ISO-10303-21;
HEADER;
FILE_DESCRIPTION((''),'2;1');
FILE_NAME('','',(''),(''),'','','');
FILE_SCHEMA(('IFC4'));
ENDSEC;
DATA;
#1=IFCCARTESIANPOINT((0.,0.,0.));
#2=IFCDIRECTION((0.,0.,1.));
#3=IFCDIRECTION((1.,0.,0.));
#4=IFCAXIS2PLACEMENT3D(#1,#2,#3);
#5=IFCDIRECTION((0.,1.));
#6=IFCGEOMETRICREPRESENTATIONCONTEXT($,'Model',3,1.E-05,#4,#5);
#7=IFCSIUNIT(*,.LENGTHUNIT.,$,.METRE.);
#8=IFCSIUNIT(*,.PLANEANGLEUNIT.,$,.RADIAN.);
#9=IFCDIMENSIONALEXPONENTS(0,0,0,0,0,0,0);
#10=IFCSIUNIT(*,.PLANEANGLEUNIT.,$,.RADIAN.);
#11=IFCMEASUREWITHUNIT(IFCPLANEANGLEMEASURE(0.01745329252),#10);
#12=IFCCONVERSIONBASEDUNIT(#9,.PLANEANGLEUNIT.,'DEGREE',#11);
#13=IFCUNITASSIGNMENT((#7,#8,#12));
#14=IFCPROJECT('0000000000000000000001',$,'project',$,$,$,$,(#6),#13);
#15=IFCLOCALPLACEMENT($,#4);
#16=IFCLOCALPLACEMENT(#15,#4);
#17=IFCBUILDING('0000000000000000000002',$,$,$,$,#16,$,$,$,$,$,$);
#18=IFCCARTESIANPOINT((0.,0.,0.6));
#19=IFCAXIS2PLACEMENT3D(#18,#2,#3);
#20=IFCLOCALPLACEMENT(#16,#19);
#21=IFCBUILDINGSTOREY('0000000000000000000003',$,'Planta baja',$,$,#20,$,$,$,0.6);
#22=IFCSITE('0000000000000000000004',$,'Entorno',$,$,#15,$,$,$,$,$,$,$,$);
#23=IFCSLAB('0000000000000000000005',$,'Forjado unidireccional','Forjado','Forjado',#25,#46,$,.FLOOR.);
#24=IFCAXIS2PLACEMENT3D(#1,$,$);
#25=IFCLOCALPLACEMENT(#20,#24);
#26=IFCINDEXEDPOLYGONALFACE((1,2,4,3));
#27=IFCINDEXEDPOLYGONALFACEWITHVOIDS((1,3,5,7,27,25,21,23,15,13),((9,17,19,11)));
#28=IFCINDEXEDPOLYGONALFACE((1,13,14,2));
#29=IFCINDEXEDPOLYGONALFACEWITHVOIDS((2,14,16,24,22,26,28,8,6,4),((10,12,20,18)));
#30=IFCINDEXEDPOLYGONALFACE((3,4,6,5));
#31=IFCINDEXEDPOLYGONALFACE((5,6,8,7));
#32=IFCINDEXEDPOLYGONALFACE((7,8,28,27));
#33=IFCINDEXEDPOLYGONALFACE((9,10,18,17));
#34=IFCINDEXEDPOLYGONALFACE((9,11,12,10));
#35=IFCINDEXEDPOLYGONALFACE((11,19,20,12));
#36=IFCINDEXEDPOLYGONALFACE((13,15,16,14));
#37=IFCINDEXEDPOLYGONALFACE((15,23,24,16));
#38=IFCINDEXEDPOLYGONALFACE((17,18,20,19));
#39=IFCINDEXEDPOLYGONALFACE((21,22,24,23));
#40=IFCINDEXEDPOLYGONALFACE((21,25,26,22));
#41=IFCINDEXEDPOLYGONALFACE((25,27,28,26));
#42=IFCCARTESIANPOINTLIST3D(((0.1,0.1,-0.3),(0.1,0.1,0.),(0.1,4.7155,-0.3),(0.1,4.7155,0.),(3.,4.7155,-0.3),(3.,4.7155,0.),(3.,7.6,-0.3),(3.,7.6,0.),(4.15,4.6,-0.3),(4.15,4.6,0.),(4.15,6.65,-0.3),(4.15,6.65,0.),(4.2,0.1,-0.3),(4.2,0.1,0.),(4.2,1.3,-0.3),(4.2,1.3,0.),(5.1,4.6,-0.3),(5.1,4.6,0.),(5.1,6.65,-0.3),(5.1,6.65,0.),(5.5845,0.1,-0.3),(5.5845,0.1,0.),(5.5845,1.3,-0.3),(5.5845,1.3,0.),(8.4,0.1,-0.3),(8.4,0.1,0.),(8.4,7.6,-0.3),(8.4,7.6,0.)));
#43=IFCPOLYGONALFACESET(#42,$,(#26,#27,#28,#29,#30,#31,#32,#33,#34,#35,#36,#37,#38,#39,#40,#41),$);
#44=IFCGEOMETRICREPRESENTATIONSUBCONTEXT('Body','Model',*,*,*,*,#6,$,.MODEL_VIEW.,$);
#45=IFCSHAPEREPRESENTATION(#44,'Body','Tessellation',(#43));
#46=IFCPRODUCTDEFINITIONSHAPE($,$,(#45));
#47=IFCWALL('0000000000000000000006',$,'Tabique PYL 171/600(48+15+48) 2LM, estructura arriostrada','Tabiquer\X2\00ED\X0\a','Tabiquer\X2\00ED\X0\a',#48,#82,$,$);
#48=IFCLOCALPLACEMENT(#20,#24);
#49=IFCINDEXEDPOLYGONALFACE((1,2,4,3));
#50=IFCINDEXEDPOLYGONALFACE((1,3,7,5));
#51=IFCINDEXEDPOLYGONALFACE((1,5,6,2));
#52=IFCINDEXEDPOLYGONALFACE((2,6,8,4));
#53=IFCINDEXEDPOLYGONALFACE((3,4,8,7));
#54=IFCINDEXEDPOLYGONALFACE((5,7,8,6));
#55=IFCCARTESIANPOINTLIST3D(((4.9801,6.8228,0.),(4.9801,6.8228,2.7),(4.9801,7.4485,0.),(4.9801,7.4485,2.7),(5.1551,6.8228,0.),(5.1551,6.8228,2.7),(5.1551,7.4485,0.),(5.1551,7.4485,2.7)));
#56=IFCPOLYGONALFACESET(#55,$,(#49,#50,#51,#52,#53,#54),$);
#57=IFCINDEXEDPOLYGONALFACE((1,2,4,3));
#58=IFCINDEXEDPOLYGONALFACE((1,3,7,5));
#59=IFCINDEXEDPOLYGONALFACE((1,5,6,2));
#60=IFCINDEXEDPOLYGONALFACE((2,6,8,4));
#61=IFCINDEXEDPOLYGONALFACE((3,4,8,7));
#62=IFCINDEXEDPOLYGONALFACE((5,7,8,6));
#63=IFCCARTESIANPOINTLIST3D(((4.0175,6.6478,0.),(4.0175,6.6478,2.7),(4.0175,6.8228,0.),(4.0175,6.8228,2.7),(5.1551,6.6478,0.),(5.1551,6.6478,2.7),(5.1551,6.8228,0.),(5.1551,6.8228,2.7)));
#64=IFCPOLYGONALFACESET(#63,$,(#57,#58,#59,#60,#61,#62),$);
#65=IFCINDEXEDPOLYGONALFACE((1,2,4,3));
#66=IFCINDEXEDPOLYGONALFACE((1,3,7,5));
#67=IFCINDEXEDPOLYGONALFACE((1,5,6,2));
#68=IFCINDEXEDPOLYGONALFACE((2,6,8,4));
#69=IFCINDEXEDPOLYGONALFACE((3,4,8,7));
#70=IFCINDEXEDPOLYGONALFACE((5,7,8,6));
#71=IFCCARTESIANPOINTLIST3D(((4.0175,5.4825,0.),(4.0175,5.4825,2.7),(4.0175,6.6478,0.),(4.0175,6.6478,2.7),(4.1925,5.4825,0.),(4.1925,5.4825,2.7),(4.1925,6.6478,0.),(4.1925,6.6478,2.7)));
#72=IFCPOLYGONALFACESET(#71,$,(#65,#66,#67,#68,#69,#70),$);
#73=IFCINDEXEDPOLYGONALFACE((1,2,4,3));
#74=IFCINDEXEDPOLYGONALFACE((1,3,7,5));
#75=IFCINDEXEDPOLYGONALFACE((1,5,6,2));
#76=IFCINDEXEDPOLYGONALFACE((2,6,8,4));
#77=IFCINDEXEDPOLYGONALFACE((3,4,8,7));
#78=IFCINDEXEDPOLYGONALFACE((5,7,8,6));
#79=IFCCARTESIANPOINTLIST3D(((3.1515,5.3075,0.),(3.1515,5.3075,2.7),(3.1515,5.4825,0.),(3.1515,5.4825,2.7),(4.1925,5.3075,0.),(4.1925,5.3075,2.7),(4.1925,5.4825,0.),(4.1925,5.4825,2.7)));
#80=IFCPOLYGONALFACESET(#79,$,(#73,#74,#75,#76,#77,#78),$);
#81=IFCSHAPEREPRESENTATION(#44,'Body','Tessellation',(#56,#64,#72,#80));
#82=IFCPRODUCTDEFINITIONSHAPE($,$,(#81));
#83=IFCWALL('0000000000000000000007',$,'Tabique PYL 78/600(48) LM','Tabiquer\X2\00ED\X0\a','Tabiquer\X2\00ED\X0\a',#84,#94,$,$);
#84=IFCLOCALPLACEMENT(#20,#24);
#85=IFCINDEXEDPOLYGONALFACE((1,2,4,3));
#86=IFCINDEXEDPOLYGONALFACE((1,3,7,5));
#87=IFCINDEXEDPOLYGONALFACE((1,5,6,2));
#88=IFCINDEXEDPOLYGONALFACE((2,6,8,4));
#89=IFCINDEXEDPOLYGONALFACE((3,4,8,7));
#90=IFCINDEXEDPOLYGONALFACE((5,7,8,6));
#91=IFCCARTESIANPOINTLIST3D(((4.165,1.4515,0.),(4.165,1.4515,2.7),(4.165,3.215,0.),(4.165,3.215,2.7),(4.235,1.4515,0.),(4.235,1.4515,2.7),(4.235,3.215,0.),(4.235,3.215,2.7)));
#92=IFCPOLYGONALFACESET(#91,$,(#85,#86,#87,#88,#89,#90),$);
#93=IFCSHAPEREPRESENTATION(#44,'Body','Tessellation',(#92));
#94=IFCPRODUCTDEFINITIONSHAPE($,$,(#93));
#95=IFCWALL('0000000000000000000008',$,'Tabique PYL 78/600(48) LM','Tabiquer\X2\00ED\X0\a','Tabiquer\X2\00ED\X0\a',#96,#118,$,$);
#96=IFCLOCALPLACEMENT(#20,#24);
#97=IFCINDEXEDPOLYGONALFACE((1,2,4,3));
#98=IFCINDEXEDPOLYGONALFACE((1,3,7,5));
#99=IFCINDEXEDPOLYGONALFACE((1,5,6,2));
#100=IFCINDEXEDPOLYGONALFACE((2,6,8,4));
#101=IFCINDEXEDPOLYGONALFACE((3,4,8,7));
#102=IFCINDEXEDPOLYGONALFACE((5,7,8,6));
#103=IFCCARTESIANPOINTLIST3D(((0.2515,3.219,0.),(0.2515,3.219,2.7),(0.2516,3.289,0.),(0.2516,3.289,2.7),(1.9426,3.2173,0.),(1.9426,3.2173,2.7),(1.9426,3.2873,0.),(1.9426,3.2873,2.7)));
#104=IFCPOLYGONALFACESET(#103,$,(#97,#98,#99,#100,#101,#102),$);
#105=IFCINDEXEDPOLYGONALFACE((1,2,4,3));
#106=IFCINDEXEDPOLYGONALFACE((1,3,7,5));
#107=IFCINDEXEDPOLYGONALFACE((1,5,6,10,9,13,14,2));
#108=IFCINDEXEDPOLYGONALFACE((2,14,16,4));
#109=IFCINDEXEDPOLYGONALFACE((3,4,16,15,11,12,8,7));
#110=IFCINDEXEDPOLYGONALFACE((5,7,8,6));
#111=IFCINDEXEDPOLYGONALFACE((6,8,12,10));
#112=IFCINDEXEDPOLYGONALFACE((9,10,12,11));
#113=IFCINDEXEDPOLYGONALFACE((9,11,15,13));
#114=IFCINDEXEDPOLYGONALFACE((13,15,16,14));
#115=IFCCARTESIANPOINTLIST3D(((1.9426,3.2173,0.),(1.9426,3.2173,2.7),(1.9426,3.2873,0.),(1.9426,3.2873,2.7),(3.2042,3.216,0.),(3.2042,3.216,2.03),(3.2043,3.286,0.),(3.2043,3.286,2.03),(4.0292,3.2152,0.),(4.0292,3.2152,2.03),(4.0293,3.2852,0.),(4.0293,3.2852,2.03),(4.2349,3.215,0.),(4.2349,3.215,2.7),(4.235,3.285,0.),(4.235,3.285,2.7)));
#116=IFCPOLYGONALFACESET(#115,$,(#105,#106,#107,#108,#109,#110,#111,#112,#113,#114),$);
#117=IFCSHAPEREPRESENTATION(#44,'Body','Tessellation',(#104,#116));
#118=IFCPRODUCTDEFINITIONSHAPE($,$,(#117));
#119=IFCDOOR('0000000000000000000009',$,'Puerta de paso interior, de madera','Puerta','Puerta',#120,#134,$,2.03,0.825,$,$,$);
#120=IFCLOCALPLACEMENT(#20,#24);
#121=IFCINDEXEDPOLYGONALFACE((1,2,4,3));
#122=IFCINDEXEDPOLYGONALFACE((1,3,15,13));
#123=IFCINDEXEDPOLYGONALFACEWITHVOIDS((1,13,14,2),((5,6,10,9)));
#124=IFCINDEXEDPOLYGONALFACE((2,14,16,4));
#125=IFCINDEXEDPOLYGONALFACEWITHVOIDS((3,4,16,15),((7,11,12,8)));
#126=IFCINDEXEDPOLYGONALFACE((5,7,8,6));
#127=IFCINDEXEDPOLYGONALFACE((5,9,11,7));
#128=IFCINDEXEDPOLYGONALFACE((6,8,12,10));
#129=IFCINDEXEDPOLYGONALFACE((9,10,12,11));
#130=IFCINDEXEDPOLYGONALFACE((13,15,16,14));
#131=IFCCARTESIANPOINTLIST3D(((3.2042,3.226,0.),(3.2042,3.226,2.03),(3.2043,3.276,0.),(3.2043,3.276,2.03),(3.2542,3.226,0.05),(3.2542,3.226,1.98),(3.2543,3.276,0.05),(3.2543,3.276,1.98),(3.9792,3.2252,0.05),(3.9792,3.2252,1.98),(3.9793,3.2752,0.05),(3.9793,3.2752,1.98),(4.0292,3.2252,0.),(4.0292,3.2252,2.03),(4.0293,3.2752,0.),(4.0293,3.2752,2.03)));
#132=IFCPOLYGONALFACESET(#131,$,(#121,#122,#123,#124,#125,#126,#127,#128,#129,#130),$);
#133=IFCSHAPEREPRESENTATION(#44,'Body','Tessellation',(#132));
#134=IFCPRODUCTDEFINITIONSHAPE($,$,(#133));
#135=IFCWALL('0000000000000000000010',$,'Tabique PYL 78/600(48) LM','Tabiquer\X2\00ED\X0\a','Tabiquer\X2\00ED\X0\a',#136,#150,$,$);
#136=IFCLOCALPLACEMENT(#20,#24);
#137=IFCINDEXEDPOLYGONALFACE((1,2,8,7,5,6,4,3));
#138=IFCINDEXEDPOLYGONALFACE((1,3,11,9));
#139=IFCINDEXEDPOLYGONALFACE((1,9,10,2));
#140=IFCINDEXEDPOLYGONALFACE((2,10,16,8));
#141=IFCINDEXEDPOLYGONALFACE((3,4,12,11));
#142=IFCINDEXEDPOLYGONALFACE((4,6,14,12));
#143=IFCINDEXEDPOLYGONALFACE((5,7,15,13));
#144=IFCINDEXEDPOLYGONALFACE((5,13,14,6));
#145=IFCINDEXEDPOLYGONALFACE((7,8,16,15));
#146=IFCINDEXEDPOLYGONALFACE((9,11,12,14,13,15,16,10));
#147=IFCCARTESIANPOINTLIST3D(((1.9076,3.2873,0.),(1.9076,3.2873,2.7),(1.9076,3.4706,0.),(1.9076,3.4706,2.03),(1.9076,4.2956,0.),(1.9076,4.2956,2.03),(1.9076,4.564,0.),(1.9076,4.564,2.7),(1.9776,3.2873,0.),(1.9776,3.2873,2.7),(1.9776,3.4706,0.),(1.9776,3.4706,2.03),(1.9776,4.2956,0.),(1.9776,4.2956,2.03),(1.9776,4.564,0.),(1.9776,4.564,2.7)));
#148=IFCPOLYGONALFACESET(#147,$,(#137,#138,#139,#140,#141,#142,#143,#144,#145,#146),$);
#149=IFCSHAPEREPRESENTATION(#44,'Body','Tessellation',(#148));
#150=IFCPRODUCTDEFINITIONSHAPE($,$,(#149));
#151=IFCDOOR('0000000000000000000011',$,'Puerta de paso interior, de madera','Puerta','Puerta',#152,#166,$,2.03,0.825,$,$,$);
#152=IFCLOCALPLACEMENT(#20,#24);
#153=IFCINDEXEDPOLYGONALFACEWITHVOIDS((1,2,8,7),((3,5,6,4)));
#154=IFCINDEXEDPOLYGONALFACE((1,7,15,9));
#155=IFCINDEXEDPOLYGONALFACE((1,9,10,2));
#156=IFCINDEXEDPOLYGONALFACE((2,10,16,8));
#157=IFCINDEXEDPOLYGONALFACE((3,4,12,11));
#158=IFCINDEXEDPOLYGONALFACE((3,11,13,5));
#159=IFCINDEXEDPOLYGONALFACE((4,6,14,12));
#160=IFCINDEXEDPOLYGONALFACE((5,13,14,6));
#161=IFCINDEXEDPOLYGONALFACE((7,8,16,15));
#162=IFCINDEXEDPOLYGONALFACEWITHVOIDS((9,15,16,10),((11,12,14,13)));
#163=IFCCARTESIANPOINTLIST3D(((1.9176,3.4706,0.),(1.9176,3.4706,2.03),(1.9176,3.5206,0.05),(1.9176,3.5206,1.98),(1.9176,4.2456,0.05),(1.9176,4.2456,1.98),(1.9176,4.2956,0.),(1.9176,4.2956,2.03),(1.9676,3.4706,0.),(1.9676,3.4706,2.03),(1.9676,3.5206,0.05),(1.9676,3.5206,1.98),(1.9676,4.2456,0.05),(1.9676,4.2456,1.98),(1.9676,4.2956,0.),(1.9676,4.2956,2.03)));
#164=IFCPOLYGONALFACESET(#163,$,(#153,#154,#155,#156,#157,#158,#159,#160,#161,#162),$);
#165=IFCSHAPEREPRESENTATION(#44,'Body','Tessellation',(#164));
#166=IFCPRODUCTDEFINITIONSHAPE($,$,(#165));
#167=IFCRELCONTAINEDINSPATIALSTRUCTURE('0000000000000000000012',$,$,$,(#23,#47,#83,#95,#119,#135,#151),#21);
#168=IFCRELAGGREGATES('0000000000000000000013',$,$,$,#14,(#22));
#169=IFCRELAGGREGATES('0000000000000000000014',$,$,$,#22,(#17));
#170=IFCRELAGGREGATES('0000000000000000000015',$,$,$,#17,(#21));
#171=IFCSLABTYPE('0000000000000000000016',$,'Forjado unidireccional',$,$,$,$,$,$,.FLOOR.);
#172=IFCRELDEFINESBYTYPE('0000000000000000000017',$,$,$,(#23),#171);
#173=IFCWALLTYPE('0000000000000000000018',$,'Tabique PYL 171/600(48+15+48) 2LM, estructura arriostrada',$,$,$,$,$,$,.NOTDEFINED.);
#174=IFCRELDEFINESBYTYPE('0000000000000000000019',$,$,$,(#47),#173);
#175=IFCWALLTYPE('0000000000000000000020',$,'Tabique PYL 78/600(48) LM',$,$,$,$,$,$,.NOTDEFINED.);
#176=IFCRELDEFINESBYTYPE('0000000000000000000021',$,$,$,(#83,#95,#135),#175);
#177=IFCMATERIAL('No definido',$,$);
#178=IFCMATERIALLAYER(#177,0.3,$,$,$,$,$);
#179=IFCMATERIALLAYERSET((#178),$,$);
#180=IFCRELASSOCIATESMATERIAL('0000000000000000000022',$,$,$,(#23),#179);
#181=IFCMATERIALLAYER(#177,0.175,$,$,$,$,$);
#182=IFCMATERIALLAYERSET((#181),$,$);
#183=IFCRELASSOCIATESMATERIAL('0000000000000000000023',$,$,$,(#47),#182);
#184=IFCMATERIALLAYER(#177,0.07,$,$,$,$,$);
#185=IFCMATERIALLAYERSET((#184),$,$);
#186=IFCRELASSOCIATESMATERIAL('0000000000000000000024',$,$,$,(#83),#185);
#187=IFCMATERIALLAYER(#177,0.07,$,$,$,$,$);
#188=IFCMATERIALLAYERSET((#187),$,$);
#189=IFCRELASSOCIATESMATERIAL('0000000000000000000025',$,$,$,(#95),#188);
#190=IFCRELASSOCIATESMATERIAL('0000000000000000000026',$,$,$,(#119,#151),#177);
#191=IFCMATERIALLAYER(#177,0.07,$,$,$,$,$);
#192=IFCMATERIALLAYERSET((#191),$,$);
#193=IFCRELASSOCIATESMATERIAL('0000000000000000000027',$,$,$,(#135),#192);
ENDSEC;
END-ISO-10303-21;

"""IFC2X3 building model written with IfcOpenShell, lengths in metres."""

from ifc_helpers import new_model, entity, si_unit, converted_unit, direction, frame, origin_with_axes, origin_2d_with_axis, place, context, subcontext, project, spatial, polyline, rectangle, hollow_rectangle, outline, extrude, shape, material, layer, layer_set, layer_usage, type_object, element, fill, save


model = new_model("IFC2X3")

# Units and contexts
model_context = context("Model", 3, precision=1e-05, world=origin_with_axes(), true_north=direction((0.0, 1.0)))
body_context = subcontext(model_context, "Body", "Model", "MODEL_VIEW")
footprint_context = subcontext(model_context, "FootPrint", "Model", "MODEL_VIEW")
ifc_project = project(units=[si_unit("LENGTHUNIT", "METRE"), si_unit("PLANEANGLEUNIT", "RADIAN"), converted_unit("PLANEANGLEUNIT", "DEGREE", entity("IfcPlaneAngleMeasure", 0.01745329252), si_unit("PLANEANGLEUNIT", "RADIAN"), dimensions=[0, 0, 0, 0, 0, 0, 0])], contexts=[model_context])

# Site, building, storey
site_placement = place(None, origin_with_axes())
site = spatial("IfcSite", under=ifc_project, at=site_placement, Name="Entorno")
building_placement = place(site_placement, origin_with_axes())
building = spatial("IfcBuilding", under=site, at=building_placement)
storey_placement = place(building_placement, frame((0.0, 0.0, 0.6), z_axis=(0.0, 0.0, 1.0), x_axis=(1.0, 0.0, 0.0)))
storey = spatial("IfcBuildingStorey", under=building, at=storey_placement, Name="Planta baja", Elevation=0.6)

# Slab, opening
ifc_material = material(Name="No definido")
ifc_layer_1 = layer(ifc_material, 0.3)
ifc_layer_set_1 = layer_set([ifc_layer_1])
ifc_layer_usage_1 = layer_usage(ifc_layer_set_1, "AXIS3", "POSITIVE", 0.0)
slab_type_1 = type_object("IfcSlabType", Name="Forjado unidireccional", PredefinedType="FLOOR")
slab_placement = place(storey_placement, frame((4.2, 0.1, -0.3), z_axis=(0.0, 0.0, 1.0), x_axis=(1.0, 0.0, 0.0)))
slab = element("IfcSlab", 1, at=slab_placement, inside=storey, type_object=slab_type_1, material=ifc_layer_usage_1, Name="Forjado unidireccional", Description="Forjado", ObjectType="Forjado", PredefinedType="FLOOR", context=body_context, shape_type="SweptSolid", body=[
    extrude(outline(polyline([(0.0, 0.0), (0.0, 1.2), (1.3845, 1.2), (1.3845, 0.0), (4.2, 0.0), (4.2, 7.5), (-1.2, 7.5), (-1.2, 4.6155), (-4.1, 4.6155), (-4.1, 0.0), (0.0, 0.0)])), origin_with_axes(), (0.0, 0.0, 1.0), 0.3),
])
opening_1_placement = place(slab_placement, frame((-0.05, 4.5, -0.01), z_axis=(0.0, 0.0, 1.0), x_axis=(1.0, 0.0, 0.0)))
element("IfcOpeningElement", 2, at=opening_1_placement, cuts=slab, ObjectType="No definido", context=body_context, shape_type="SweptSolid", body=[
    extrude(outline(polyline([(0.0, 0.0), (0.95, 0.0), (0.95, 2.05), (0.0, 2.05), (0.0, 0.0)])), origin_with_axes(), (0.0, 0.0, 1.0), 0.32),
])

# Walls
ifc_layer_2 = layer(ifc_material, 0.175)
ifc_layer_set_2 = layer_set([ifc_layer_2])
ifc_layer_usage_2 = layer_usage(ifc_layer_set_2, "AXIS2", "POSITIVE", -0.0875)
wall_type_1 = type_object("IfcWallType", Name="Tabique PYL 171/600(48+15+48) 2LM, estructura arriostrada")
wall_1_placement = place(storey_placement, frame((5.0676, 7.6, 0.0), z_axis=(0.0, 0.0, 1.0), x_axis=(0.0, -1.0, 0.0)))
element("IfcWall", 3, at=wall_1_placement, inside=storey, type_object=wall_type_1, material=ifc_layer_usage_2, Name="Tabique PYL 171/600(48+15+48) 2LM, estructura arriostrada", Description="Tabiquería", ObjectType="Tabiquería", context=body_context, shape_type="SolidModel", body=[
    extrude(outline(polyline([(-0.3129, -1.35), (0.3129, -1.35), (0.3129, 1.35), (-0.3129, 1.35), (-0.3129, -1.35)])), frame((0.4643, 0.0875, 1.35), z_axis=(0.0, -1.0, 0.0), x_axis=(1.0, 0.0, 0.0)), (0.0, 0.0, 1.0), 0.175),
    extrude(outline(polyline([(-0.5688, -1.35), (0.5688, -1.35), (0.5688, 1.35), (-0.5688, 1.35), (-0.5688, -1.35)])), frame((0.9522, -0.4813, 1.35), z_axis=(-1.0, 0.0, 0.0), x_axis=(0.0, -1.0, 0.0)), (0.0, 0.0, 1.0), 0.175),
    extrude(outline(polyline([(-0.5827, -1.35), (0.5827, -1.35), (0.5827, 1.35), (-0.5827, 1.35), (-0.5827, -1.35)])), frame((1.5349, -0.8751, 1.35), z_axis=(0.0, -1.0, 0.0), x_axis=(1.0, 0.0, 0.0)), (0.0, 0.0, 1.0), 0.175),
    extrude(outline(polyline([(-0.5205, -1.35), (0.5205, -1.35), (0.5205, 1.35), (-0.5205, 1.35), (-0.5205, -1.35)])), frame((2.2925, -1.3956, 1.35), z_axis=(-1.0, 0.0, 0.0), x_axis=(0.0, -1.0, 0.0)), (0.0, 0.0, 1.0), 0.175),
])
ifc_layer_3 = layer(ifc_material, 0.07)
ifc_layer_set_3 = layer_set([ifc_layer_3])
ifc_layer_usage_3 = layer_usage(ifc_layer_set_3, "AXIS2", "POSITIVE", -0.035)
wall_type_2 = type_object("IfcWallType", Name="Tabique PYL 78/600(48) LM")
wall_2_placement = place(storey_placement, frame((4.2, 1.3, 0.0), z_axis=(0.0, 0.0, 1.0), x_axis=(0.0, 1.0, 0.0)))
element("IfcWall", 4, at=wall_2_placement, inside=storey, type_object=wall_type_2, material=ifc_layer_usage_3, Name="Tabique PYL 78/600(48) LM", Description="Tabiquería", ObjectType="Tabiquería", context=body_context, shape_type="SolidModel", body=[
    extrude(outline(polyline([(-0.8817, -1.35), (0.8817, -1.35), (0.8817, 1.35), (-0.8817, 1.35), (-0.8817, -1.35)])), frame((1.0332, 0.035, 1.35), z_axis=(0.0, -1.0, 0.0), x_axis=(1.0, 0.0, 0.0)), (0.0, 0.0, 1.0), 0.07),
])

# Walls, openings, doors
ifc_layer_4 = layer(ifc_material, 0.07)
ifc_layer_set_4 = layer_set([ifc_layer_4])
ifc_layer_usage_4 = layer_usage(ifc_layer_set_4, "AXIS2", "POSITIVE", -0.035)
wall_3_placement = place(storey_placement, frame((0.1, 3.2542, 0.0), z_axis=(0.0, 0.0, 1.0), x_axis=(0.999999, -0.001016, 0.0)))
wall_3 = element("IfcWall", 5, at=wall_3_placement, inside=storey, type_object=wall_type_2, material=ifc_layer_usage_4, Name="Tabique PYL 78/600(48) LM", Description="Tabiquería", ObjectType="Tabiquería", context=body_context, shape_type="SolidModel", body=[
    extrude(outline(polyline([(-0.8455, -1.35), (0.8455, -1.35), (0.8455, 1.35), (-0.8455, 1.35), (-0.8455, -1.35)])), frame((0.9971, 0.035, 1.35), z_axis=(0.0, -1.0, 0.0), x_axis=(1.0, 0.0, 0.0)), (0.0, 0.0, 1.0), 0.07),
    extrude(outline(polyline([(-1.1462, -1.35), (1.1462, -1.35), (1.1462, 1.35), (-1.1462, 1.35), (-1.1462, -1.35)])), frame((2.9888, 0.035, 1.35), z_axis=(0.0, -1.0, 0.0), x_axis=(1.0, 0.0, 0.0)), (0.0, 0.0, 1.0), 0.07),
])
opening_2_placement = place(wall_3_placement, frame((3.5168, 0.0, 1.015), z_axis=(0.0, 0.0, 1.0), x_axis=(1.0, 0.0, 0.0)))
cartesian_point_1 = entity("IfcCartesianPoint", [-0.4125, -0.035])
opening_2 = element("IfcOpeningElement", 6, at=opening_2_placement, cuts=wall_3, ObjectType="No definido", shapes=[
    shape(body_context, "Body", "SweptSolid", [extrude(rectangle(XDim=2.03, YDim=0.825, at=origin_2d_with_axis()), frame((0.0, -0.035, 0.0), z_axis=(0.0, 1.0, 0.0), x_axis=(0.0, 0.0, 1.0)), (0.0, 0.0, 1.0), 0.07)]),
    shape(footprint_context, "FootPrint", "GeometricCurveSet", [entity("IfcGeometricCurveSet", [entity("IfcPolyline", [cartesian_point_1, entity("IfcCartesianPoint", [0.4125, -0.035]), entity("IfcCartesianPoint", [0.4125, 0.035]), entity("IfcCartesianPoint", [-0.4125, 0.035]), cartesian_point_1])])]),
])
door_1_placement = place(opening_2_placement, origin_with_axes())
door_1 = element("IfcDoor", 7, at=door_1_placement, inside=storey, material=ifc_material, Name="Puerta de paso interior, de madera", Description="Puerta", ObjectType="Puerta", OverallHeight=2.03, OverallWidth=0.825, context=body_context, shape_type="SweptSolid", body=[
    extrude(hollow_rectangle(XDim=0.825, YDim=2.03, WallThickness=0.05, InnerFilletRadius=0.0, OuterFilletRadius=0.0, at=origin_2d_with_axis()), frame((0.0, 0.025, 0.0), z_axis=(0.0, -1.0, 0.0), x_axis=(1.0, 0.0, 0.0)), (0.0, 0.0, 1.0), 0.05),
])
fill(opening_2, door_1)
ifc_layer_5 = layer(ifc_material, 0.07)
ifc_layer_set_5 = layer_set([ifc_layer_5])
ifc_layer_usage_5 = layer_usage(ifc_layer_set_5, "AXIS2", "POSITIVE", -0.035)
wall_4_placement = place(storey_placement, frame((1.9426, 3.25, 0.0), z_axis=(0.0, 0.0, 1.0), x_axis=(0.0, 1.0, 0.0)))
wall_4 = element("IfcWall", 8, at=wall_4_placement, inside=storey, type_object=wall_type_2, material=ifc_layer_usage_5, Name="Tabique PYL 78/600(48) LM", Description="Tabiquería", ObjectType="Tabiquería", context=body_context, shape_type="SolidModel", body=[
    extrude(outline(polyline([(-0.6383, -1.35), (0.6383, -1.35), (0.6383, 1.35), (-0.6383, 1.35), (-0.6383, -1.35)])), frame((0.6757, 0.035, 1.35), z_axis=(0.0, -1.0, 0.0), x_axis=(1.0, 0.0, 0.0)), (0.0, 0.0, 1.0), 0.07),
])
opening_3_placement = place(wall_4_placement, frame((0.6331, 0.0, 1.015), z_axis=(0.0, 0.0, 1.0), x_axis=(1.0, 0.0, 0.0)))
cartesian_point_2 = entity("IfcCartesianPoint", [-0.4125, -0.035])
opening_3 = element("IfcOpeningElement", 9, at=opening_3_placement, cuts=wall_4, ObjectType="No definido", shapes=[
    shape(body_context, "Body", "SweptSolid", [extrude(rectangle(XDim=2.03, YDim=0.825, at=origin_2d_with_axis()), frame((0.0, -0.035, 0.0), z_axis=(0.0, 1.0, 0.0), x_axis=(0.0, 0.0, 1.0)), (0.0, 0.0, 1.0), 0.07)]),
    shape(footprint_context, "FootPrint", "GeometricCurveSet", [entity("IfcGeometricCurveSet", [entity("IfcPolyline", [cartesian_point_2, entity("IfcCartesianPoint", [0.4125, -0.035]), entity("IfcCartesianPoint", [0.4125, 0.035]), entity("IfcCartesianPoint", [-0.4125, 0.035]), cartesian_point_2])])]),
])
door_2_placement = place(opening_3_placement, origin_with_axes())
door_2 = element("IfcDoor", 10, at=door_2_placement, inside=storey, material=ifc_material, Name="Puerta de paso interior, de madera", Description="Puerta", ObjectType="Puerta", OverallHeight=2.03, OverallWidth=0.825, context=body_context, shape_type="SweptSolid", body=[
    extrude(hollow_rectangle(XDim=0.825, YDim=2.03, WallThickness=0.05, InnerFilletRadius=0.0, OuterFilletRadius=0.0, at=origin_2d_with_axis()), frame((0.0, 0.025, 0.0), z_axis=(0.0, -1.0, 0.0), x_axis=(1.0, 0.0, 0.0)), (0.0, 0.0, 1.0), 0.05),
])
fill(opening_3, door_2)

save(model, "model.ifc")
